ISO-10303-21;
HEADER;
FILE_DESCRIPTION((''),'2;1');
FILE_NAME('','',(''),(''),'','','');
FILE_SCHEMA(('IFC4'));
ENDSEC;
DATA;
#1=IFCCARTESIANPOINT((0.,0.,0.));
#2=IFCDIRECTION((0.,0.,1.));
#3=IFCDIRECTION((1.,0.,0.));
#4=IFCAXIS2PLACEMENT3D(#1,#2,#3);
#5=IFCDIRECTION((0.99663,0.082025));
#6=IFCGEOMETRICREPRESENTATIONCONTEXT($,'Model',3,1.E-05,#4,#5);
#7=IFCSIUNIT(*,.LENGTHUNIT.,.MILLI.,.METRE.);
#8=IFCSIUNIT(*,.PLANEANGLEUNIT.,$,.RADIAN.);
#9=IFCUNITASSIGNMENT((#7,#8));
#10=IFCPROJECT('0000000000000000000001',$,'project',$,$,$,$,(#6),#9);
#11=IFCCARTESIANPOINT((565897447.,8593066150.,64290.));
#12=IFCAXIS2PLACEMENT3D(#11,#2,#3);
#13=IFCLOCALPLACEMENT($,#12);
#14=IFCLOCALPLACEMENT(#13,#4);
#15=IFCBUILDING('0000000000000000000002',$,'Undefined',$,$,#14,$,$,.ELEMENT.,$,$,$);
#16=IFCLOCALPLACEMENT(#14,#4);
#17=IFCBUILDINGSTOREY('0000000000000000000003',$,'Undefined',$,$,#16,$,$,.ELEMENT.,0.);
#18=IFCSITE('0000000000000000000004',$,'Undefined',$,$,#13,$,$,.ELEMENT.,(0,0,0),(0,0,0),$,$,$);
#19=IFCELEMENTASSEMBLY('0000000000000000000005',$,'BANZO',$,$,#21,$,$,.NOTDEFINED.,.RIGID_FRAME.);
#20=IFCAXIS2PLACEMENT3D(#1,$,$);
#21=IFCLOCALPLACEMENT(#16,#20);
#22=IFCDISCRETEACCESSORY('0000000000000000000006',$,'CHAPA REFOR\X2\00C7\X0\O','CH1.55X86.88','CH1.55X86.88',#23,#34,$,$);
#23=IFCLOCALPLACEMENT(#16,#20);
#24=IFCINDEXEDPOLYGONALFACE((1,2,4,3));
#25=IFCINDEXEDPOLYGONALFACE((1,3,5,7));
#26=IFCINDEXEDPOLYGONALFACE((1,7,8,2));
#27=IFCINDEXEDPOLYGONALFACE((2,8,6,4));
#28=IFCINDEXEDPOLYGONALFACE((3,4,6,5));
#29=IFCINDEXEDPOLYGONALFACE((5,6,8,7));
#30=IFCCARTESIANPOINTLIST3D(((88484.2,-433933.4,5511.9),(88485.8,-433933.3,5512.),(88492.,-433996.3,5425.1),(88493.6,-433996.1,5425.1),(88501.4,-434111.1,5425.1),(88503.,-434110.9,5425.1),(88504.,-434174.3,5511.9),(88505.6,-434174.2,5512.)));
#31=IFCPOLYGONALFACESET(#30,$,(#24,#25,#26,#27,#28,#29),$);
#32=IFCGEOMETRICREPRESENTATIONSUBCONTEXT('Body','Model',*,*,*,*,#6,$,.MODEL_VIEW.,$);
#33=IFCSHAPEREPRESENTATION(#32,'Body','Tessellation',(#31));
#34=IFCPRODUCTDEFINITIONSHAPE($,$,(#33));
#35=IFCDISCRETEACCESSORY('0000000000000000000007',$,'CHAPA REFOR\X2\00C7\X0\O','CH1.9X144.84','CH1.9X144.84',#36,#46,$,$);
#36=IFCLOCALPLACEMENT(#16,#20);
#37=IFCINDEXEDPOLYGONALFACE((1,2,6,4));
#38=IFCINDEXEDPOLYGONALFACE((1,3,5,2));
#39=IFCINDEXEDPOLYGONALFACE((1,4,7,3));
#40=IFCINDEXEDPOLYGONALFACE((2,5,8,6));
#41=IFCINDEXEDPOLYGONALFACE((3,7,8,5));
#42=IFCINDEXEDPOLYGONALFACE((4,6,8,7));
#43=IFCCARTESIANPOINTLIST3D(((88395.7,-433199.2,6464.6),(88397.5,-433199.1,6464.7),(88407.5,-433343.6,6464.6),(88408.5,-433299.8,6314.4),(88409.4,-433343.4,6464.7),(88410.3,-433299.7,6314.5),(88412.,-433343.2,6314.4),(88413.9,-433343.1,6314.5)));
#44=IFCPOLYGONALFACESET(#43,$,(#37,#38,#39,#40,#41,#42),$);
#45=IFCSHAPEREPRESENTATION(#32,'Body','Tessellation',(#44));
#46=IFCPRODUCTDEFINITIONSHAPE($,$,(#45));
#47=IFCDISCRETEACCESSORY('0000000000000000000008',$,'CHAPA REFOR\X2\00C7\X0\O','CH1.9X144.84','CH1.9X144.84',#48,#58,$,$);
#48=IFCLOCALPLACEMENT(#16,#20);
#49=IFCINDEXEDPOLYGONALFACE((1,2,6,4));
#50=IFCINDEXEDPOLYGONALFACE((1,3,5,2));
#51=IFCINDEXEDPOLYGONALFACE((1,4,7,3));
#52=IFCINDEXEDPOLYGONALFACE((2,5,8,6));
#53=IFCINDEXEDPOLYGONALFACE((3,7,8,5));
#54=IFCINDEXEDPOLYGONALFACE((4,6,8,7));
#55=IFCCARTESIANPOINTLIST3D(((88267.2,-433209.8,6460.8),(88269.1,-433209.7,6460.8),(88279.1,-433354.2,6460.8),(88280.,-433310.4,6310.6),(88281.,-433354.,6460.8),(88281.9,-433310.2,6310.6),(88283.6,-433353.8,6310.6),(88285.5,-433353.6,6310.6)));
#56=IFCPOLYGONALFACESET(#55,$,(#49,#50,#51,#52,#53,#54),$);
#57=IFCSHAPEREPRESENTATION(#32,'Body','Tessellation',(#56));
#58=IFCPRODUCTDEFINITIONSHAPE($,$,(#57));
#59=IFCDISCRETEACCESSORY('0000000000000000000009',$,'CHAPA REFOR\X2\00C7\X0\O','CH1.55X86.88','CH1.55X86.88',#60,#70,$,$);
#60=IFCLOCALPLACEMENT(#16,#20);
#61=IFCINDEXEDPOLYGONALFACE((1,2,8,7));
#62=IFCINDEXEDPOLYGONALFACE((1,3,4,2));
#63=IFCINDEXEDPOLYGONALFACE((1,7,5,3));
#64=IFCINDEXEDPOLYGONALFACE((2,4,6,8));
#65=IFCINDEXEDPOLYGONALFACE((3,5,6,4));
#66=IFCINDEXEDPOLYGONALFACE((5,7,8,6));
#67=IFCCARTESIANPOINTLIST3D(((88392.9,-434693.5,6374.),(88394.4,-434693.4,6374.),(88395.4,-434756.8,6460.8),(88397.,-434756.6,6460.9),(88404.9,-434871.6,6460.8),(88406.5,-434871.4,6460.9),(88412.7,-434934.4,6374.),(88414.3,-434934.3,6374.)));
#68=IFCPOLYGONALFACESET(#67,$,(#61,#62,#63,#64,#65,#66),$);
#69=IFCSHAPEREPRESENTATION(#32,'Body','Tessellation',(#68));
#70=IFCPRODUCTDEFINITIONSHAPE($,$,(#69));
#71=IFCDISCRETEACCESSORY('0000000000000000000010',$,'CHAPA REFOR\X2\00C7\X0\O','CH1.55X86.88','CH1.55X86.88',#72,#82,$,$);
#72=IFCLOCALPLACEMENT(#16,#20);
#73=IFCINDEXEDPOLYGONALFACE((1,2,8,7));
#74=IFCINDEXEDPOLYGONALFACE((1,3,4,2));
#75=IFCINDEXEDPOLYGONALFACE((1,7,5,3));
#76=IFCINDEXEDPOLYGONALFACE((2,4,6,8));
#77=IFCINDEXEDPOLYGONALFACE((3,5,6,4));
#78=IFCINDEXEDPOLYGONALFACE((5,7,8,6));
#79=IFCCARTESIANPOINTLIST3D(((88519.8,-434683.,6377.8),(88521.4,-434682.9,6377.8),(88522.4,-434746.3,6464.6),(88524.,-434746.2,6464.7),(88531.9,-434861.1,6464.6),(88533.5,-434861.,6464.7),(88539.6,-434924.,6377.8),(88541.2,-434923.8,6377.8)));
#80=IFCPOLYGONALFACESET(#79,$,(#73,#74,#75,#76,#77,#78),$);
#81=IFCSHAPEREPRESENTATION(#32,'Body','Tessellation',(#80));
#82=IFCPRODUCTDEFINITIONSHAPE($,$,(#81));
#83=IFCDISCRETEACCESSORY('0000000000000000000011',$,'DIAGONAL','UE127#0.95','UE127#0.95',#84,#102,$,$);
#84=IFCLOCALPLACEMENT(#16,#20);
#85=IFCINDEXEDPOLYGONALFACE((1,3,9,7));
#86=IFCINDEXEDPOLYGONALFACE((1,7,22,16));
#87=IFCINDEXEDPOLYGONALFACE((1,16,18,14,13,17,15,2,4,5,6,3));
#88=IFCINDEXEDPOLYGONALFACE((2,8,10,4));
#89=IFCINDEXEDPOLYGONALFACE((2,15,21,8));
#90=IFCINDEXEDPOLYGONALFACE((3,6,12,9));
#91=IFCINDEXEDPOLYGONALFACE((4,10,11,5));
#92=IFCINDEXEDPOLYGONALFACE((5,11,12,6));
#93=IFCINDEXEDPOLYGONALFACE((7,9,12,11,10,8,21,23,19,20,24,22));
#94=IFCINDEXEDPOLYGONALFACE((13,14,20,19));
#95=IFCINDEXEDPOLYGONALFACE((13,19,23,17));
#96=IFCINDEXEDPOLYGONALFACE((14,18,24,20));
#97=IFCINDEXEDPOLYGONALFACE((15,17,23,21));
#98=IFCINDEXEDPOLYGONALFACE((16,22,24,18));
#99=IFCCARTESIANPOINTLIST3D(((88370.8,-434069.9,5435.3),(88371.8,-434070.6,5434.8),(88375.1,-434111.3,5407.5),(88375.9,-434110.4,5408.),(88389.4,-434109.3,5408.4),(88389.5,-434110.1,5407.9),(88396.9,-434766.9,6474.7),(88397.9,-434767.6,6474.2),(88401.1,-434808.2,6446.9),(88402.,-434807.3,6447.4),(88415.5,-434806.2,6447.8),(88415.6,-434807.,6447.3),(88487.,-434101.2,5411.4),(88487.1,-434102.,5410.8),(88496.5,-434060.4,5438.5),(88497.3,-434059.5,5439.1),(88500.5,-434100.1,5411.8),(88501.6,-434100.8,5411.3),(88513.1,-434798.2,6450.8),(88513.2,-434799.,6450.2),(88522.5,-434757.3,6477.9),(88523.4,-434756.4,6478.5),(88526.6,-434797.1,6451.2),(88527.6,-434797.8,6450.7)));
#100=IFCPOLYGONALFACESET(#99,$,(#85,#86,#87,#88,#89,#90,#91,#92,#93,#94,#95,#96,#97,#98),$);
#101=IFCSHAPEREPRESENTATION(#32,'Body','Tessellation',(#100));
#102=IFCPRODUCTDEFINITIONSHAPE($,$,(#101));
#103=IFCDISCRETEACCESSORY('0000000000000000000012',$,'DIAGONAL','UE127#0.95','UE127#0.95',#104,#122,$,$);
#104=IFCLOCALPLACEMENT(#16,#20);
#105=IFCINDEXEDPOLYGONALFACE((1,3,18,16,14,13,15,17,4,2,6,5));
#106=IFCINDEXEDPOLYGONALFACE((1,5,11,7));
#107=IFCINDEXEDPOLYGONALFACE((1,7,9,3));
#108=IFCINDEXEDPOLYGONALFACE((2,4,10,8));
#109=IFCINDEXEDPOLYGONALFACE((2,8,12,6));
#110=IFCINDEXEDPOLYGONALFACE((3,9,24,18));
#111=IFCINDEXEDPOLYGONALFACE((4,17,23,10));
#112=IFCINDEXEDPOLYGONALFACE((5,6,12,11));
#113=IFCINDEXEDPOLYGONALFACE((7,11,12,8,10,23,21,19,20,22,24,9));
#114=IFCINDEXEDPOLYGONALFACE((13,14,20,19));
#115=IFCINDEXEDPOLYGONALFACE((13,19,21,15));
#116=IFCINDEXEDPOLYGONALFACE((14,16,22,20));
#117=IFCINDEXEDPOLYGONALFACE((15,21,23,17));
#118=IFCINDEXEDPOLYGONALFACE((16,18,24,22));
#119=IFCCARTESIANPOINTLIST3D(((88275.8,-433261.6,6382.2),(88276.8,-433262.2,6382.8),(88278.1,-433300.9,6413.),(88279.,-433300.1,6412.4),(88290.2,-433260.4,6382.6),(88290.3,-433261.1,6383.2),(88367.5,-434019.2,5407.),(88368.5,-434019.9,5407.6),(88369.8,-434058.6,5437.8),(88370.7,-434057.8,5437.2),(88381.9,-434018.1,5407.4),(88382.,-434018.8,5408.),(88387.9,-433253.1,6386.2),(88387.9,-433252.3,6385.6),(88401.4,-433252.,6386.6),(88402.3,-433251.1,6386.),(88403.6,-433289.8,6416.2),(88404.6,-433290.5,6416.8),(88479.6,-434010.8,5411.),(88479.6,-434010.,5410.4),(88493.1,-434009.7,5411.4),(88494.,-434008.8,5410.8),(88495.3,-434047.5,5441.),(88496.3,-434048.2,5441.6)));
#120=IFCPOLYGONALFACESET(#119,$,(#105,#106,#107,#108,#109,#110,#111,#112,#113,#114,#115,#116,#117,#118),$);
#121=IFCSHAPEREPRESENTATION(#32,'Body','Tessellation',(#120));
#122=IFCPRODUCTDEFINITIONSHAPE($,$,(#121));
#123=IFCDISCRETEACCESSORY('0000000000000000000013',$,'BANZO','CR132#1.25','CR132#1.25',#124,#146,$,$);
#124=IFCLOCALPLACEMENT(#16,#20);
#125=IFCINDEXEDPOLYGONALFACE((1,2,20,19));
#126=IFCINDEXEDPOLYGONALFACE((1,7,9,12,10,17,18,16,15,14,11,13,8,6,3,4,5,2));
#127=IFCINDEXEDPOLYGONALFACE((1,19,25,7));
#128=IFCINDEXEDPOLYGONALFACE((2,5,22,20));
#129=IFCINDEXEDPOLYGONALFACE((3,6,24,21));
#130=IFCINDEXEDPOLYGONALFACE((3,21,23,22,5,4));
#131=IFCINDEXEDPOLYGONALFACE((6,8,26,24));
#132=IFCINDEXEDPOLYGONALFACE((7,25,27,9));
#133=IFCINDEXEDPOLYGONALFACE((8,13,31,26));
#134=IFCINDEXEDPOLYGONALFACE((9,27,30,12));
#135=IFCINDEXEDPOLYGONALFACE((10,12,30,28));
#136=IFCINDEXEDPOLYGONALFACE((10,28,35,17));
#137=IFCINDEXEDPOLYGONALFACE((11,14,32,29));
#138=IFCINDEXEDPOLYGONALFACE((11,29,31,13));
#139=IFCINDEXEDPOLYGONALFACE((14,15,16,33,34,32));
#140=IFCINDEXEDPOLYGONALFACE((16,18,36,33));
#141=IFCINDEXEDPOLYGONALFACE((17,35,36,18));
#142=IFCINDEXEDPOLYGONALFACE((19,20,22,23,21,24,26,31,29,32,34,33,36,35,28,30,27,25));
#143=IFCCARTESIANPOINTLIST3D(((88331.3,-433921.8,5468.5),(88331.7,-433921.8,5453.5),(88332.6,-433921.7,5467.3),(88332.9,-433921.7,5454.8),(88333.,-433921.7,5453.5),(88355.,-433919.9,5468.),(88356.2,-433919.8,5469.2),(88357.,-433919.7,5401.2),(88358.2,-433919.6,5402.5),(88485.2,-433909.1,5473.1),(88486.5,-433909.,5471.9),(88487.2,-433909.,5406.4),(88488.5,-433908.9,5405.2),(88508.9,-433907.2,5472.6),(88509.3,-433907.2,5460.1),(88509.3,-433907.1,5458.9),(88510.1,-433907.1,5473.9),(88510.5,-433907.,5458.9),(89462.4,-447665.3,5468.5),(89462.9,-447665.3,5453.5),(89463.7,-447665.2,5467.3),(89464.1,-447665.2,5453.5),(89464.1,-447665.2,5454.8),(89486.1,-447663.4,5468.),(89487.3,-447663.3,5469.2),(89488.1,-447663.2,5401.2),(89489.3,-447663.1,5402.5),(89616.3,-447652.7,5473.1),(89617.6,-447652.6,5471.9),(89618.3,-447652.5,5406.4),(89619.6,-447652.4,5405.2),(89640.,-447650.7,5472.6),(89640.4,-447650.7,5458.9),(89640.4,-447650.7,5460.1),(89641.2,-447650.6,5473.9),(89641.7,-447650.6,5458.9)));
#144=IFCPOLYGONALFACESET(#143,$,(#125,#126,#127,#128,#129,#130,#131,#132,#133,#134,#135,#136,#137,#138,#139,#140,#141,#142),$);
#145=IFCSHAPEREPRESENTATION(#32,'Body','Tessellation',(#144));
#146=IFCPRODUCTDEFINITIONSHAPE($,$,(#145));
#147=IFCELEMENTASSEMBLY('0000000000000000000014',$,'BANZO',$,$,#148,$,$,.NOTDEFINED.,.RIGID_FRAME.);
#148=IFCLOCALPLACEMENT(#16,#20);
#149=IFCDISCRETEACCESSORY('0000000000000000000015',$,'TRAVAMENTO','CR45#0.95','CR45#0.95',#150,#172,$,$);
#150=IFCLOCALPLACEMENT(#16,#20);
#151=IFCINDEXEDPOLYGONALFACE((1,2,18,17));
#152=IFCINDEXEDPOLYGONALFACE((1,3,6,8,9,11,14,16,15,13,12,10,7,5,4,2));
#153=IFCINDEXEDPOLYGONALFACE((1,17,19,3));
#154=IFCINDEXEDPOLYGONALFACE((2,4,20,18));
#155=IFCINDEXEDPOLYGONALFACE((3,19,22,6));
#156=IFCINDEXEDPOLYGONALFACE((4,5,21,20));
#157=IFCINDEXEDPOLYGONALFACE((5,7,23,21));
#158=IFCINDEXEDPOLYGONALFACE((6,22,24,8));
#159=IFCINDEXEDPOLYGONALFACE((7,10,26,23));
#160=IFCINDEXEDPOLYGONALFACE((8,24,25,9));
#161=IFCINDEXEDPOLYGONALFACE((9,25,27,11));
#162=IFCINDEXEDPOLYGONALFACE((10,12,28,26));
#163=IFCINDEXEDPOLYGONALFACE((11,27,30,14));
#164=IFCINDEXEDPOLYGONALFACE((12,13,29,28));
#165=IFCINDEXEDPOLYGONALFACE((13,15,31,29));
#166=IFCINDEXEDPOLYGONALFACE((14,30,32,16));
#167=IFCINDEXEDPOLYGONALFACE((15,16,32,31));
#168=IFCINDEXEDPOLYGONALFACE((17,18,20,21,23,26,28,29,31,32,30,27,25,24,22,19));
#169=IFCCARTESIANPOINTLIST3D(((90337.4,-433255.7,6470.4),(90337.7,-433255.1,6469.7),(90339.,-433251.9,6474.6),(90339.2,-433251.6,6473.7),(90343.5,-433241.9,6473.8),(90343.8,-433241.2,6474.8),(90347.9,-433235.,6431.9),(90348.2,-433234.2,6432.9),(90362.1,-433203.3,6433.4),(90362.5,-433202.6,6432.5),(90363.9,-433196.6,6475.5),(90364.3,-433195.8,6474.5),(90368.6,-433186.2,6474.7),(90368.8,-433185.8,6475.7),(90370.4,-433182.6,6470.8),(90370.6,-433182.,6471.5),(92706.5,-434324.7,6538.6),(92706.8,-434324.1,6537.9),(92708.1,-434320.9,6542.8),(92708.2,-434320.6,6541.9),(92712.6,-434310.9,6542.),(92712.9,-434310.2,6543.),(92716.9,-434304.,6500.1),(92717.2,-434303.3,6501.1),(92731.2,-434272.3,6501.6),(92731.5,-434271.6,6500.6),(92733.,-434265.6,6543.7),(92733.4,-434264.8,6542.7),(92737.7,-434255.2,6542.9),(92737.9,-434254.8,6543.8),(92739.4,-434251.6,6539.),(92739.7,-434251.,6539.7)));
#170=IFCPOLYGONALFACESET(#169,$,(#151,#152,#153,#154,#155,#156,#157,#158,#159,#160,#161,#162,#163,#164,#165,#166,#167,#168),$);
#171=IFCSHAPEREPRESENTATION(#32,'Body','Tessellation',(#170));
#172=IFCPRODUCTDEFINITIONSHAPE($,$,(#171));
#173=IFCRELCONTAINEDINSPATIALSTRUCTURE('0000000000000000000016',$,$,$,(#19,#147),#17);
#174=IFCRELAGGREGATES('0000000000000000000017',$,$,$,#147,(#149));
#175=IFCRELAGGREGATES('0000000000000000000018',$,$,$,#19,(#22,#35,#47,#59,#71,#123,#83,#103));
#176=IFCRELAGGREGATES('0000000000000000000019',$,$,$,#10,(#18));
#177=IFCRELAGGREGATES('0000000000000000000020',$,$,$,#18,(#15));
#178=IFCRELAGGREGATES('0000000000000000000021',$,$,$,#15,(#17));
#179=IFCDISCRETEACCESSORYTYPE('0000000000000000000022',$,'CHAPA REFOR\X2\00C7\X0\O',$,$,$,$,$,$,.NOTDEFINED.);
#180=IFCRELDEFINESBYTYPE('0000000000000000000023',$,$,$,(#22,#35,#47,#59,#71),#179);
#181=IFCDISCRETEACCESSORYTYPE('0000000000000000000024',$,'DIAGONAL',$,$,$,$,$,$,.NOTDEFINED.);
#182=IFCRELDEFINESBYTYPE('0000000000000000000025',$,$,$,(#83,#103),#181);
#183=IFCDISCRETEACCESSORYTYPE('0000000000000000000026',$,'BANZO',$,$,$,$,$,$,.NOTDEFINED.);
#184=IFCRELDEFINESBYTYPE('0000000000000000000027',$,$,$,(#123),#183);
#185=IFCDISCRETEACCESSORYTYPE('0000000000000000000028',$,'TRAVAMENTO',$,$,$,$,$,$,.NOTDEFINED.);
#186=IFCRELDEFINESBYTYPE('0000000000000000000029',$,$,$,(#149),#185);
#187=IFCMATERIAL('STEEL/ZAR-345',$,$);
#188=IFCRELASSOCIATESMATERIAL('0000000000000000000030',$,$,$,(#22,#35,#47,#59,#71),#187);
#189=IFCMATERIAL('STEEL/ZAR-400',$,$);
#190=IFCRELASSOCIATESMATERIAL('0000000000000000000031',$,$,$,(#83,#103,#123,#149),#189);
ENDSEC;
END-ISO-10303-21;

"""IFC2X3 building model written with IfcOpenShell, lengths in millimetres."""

from ifc_helpers import new_model, si_unit, direction, frame, frame_2d, origin_with_axes, place, context, subcontext, project, spatial, polyline, c_section, outline, extrude, material, type_object, element, aggregate, save


model = new_model("IFC2X3")

# Units and contexts
model_context = context("Model", 3, precision=1e-05, world=origin_with_axes(), true_north=direction((0.99663, 0.082025)))
body_context = subcontext(model_context, "Body", "Model", "MODEL_VIEW")
ifc_project = project(units=[si_unit("LENGTHUNIT", "METRE", prefix="MILLI"), si_unit("PLANEANGLEUNIT", "RADIAN")], contexts=[model_context])

# Site, building, storey
site_placement = place(None, frame((565897447.0, 8593066150.0, 64290.0), z_axis=(0.0, 0.0, 1.0), x_axis=(1.0, 0.0, 0.0)))
site = spatial("IfcSite", under=ifc_project, at=site_placement, Name="Undefined", CompositionType="ELEMENT", RefLatitude=(0, 0, 0), RefLongitude=(0, 0, 0))
building_placement = place(site_placement, origin_with_axes())
building = spatial("IfcBuilding", under=site, at=building_placement, Name="Undefined", CompositionType="ELEMENT")
storey_placement = place(building_placement, origin_with_axes())
storey = spatial("IfcBuildingStorey", under=building, at=storey_placement, Name="Undefined", CompositionType="ELEMENT", Elevation=0.0)

# Element assembly
ifc_material_1 = material(Name="STEEL/ZAR-400")
assembly_1_placement = place(storey_placement, origin_with_axes())
assembly_1 = element("IfcElementAssembly", 1, at=assembly_1_placement, inside=storey, Name="BANZO", AssemblyPlace="NOTDEFINED", PredefinedType="RIGID_FRAME")

# Discrete accessories
ifc_material_2 = material(Name="STEEL/ZAR-345")
discrete_accessory_type_1 = type_object("IfcDiscreteAccessoryType", Name="CHAPA REFORÇO")
discrete_accessory_1_placement = place(assembly_1_placement, frame((88504.8, -434174.3, 5512.0), z_axis=(-0.996182, -0.081989, -0.029987), x_axis=(-0.082025, 0.99663, 0.0)))
discrete_accessory_1 = element("IfcDiscreteAccessory", 2, at=discrete_accessory_1_placement, type_object=discrete_accessory_type_1, material=ifc_material_2, Name="CHAPA REFORÇO", Description="CH1.55X86.88", ObjectType="CH1.55X86.88", context=body_context, shape_type="SweptSolid", body=[
    extrude(outline(polyline([(0.0, 0.0), (241.7, 0.0), (178.5, 86.9), (63.3, 86.9), (0.0, 0.0)])), frame((0.0, 0.0, -0.8), z_axis=(0.0, 0.0, 1.0), x_axis=(1.0, 0.0, 0.0)), (0.0, 0.0, 1.0), 1.6),
])
discrete_accessory_2_placement = place(assembly_1_placement, frame((88408.5, -433343.5, 6464.7), z_axis=(-0.996182, -0.081989, -0.029987), x_axis=(-0.082025, 0.99663, 0.0)))
discrete_accessory_2 = element("IfcDiscreteAccessory", 3, at=discrete_accessory_2_placement, type_object=discrete_accessory_type_1, material=ifc_material_2, Name="CHAPA REFORÇO", Description="CH1.9X144.84", ObjectType="CH1.9X144.84", context=body_context, shape_type="SweptSolid", body=[
    extrude(outline(polyline([(0.0, 0.0), (144.8, 0.0), (43.5, 150.3), (0.0, 150.3), (0.0, 0.0)])), frame((0.0, 0.0, -0.9), z_axis=(0.0, 0.0, 1.0), x_axis=(1.0, 0.0, 0.0)), (0.0, 0.0, 1.0), 1.9),
])
discrete_accessory_3_placement = place(assembly_1_placement, frame((88280.1, -433354.1, 6460.8), z_axis=(-0.996182, -0.081989, -0.029987), x_axis=(-0.082025, 0.99663, 0.0)))
discrete_accessory_3 = element("IfcDiscreteAccessory", 4, at=discrete_accessory_3_placement, type_object=discrete_accessory_type_1, material=ifc_material_2, Name="CHAPA REFORÇO", Description="CH1.9X144.84", ObjectType="CH1.9X144.84", context=body_context, shape_type="SweptSolid", body=[
    extrude(outline(polyline([(0.0, 0.0), (144.8, 0.0), (43.5, 150.3), (0.0, 150.3), (0.0, 0.0)])), frame((0.0, 0.0, -0.9), z_axis=(0.0, 0.0, 1.0), x_axis=(1.0, 0.0, 0.0)), (0.0, 0.0, 1.0), 1.9),
])
discrete_accessory_4_placement = place(assembly_1_placement, frame((88393.6, -434693.4, 6374.0), z_axis=(-0.996182, -0.081989, -0.029987), x_axis=(0.082025, -0.99663, 0.0)))
discrete_accessory_4 = element("IfcDiscreteAccessory", 5, at=discrete_accessory_4_placement, type_object=discrete_accessory_type_1, material=ifc_material_2, Name="CHAPA REFORÇO", Description="CH1.55X86.88", ObjectType="CH1.55X86.88", context=body_context, shape_type="SweptSolid", body=[
    extrude(outline(polyline([(0.0, 0.0), (241.7, 0.0), (178.5, 86.9), (63.3, 86.9), (0.0, 0.0)])), frame((0.0, 0.0, -0.8), z_axis=(0.0, 0.0, 1.0), x_axis=(1.0, 0.0, 0.0)), (0.0, 0.0, 1.0), 1.6),
])
discrete_accessory_5_placement = place(assembly_1_placement, frame((88520.6, -434683.0, 6377.8), z_axis=(-0.996182, -0.081989, -0.029987), x_axis=(0.082025, -0.99663, 0.0)))
discrete_accessory_5 = element("IfcDiscreteAccessory", 6, at=discrete_accessory_5_placement, type_object=discrete_accessory_type_1, material=ifc_material_2, Name="CHAPA REFORÇO", Description="CH1.55X86.88", ObjectType="CH1.55X86.88", context=body_context, shape_type="SweptSolid", body=[
    extrude(outline(polyline([(0.0, 0.0), (241.7, 0.0), (178.5, 86.9), (63.3, 86.9), (0.0, 0.0)])), frame((0.0, 0.0, -0.8), z_axis=(0.0, 0.0, 1.0), x_axis=(1.0, 0.0, 0.0)), (0.0, 0.0, 1.0), 1.6),
])
discrete_accessory_type_2 = type_object("IfcDiscreteAccessoryType", Name="DIAGONAL")
discrete_accessory_6_placement = place(assembly_1_placement, frame((88462.3, -434782.3, 6462.7), z_axis=(0.996182, 0.081989, 0.029987), x_axis=(-0.020829, 0.556784, -0.830396)))
discrete_accessory_6 = element("IfcDiscreteAccessory", 7, at=discrete_accessory_6_placement, type_object=discrete_accessory_type_2, material=ifc_material_1, Name="DIAGONAL", Description="UE127#0.95", ObjectType="UE127#0.95", context=body_context, shape_type="SweptSolid", body=[
    extrude(c_section(Depth=127.0, Width=50.0, WallThickness=0.9, Girth=14.5, at=frame_2d((0.0, 0.0), x_axis=(1.0, 0.0))), frame((1251.7, 0.0, 0.0), z_axis=(-1.0, 0.0, 0.0), x_axis=(0.0, -1.0, 0.0)), (0.0, 0.0, 1.0), 1251.7),
])
discrete_accessory_7_placement = place(assembly_1_placement, frame((88431.9, -434033.7, 5424.3), z_axis=(0.996182, 0.081989, 0.029987), x_axis=(-0.074062, 0.611853, 0.787496)))
discrete_accessory_7 = element("IfcDiscreteAccessory", 8, at=discrete_accessory_7_placement, type_object=discrete_accessory_type_2, material=ifc_material_1, Name="DIAGONAL", Description="UE127#0.95", ObjectType="UE127#0.95", context=body_context, shape_type="SweptSolid", body=[
    extrude(c_section(Depth=127.0, Width=50.0, WallThickness=0.9, Girth=14.5, at=frame_2d((0.0, 0.0), x_axis=(1.0, 0.0))), frame((1238.3, 0.0, 0.0), z_axis=(-1.0, 0.0, 0.0), x_axis=(0.0, -1.0, 0.0)), (0.0, 0.0, 1.0), 1238.3),
])
discrete_accessory_type_3 = type_object("IfcDiscreteAccessoryType", Name="BANZO")
discrete_accessory_8_placement = place(assembly_1_placement, frame((88421.7, -433914.4, 5437.2), z_axis=(0.029885, 0.00246, -0.99955), x_axis=(0.082025, -0.99663, 0.0)))
discrete_accessory_8 = element("IfcDiscreteAccessory", 9, at=discrete_accessory_8_placement, type_object=discrete_accessory_type_3, material=ifc_material_1, Name="BANZO", Description="CR132#1.25", ObjectType="CR132#1.25", context=body_context, shape_type="SweptSolid", body=[
    extrude(outline(polyline([(-64.7, 32.7), (-64.7, -34.0), (-89.7, -34.0), (-89.7, -19.0), (-88.5, -19.0), (-88.5, -20.3), (-88.5, -32.8), (-66.0, -32.8), (-66.0, 34.0), (66.0, 34.0), (66.0, -32.7), (88.5, -32.7), (88.5, -20.2), (88.5, -19.0), (89.7, -19.0), (89.7, -34.0), (64.7, -34.0), (64.7, 32.8), (-64.7, 32.7)])), frame((13790.0, 0.0, 0.0), z_axis=(-1.0, 0.0, 0.0), x_axis=(0.0, -1.0, 0.0)), (0.0, 0.0, 1.0), 13790.0),
])

# Element assembly, discrete accessory
assembly_2_placement = place(storey_placement, origin_with_axes())
assembly_2 = element("IfcElementAssembly", 10, at=assembly_2_placement, inside=storey, Name="BANZO", AssemblyPlace="NOTDEFINED", PredefinedType="RIGID_FRAME")
discrete_accessory_type_4 = type_object("IfcDiscreteAccessoryType", Name="TRAVAMENTO")
discrete_accessory_9_placement = place(assembly_2_placement, frame((90354.4, -433219.1, 6453.7), z_axis=(0.029884, 0.00246, -0.99955), x_axis=(0.911186, -0.411159, 0.02623)))
discrete_accessory_9 = element("IfcDiscreteAccessory", 11, at=discrete_accessory_9_placement, type_object=discrete_accessory_type_4, material=ifc_material_1, Name="TRAVAMENTO", Description="CR45#0.95", ObjectType="CR45#0.95", context=body_context, shape_type="SweptSolid", body=[
    extrude(outline(polyline([(-35.5, -20.5), (-24.9, -20.5), (-17.4, 21.5), (18.1, 21.5), (25.6, -20.5), (36.2, -20.5), (40.1, -16.6), (40.8, -17.3), (36.6, -21.5), (24.8, -21.5), (17.3, 20.5), (-16.6, 20.5), (-24.1, -21.5), (-35.9, -21.5), (-40.1, -17.3), (-39.4, -16.6), (-35.5, -20.5)])), frame((2600.0, 0.0, 0.0), z_axis=(-1.0, 0.0, 0.0), x_axis=(0.0, -1.0, 0.0)), (0.0, 0.0, 1.0), 2600.0),
])
aggregate(assembly_2, [discrete_accessory_9])

aggregate(assembly_1, [discrete_accessory_1, discrete_accessory_2, discrete_accessory_3, discrete_accessory_4, discrete_accessory_5, discrete_accessory_8, discrete_accessory_6, discrete_accessory_7])

save(model, "model.ifc")
